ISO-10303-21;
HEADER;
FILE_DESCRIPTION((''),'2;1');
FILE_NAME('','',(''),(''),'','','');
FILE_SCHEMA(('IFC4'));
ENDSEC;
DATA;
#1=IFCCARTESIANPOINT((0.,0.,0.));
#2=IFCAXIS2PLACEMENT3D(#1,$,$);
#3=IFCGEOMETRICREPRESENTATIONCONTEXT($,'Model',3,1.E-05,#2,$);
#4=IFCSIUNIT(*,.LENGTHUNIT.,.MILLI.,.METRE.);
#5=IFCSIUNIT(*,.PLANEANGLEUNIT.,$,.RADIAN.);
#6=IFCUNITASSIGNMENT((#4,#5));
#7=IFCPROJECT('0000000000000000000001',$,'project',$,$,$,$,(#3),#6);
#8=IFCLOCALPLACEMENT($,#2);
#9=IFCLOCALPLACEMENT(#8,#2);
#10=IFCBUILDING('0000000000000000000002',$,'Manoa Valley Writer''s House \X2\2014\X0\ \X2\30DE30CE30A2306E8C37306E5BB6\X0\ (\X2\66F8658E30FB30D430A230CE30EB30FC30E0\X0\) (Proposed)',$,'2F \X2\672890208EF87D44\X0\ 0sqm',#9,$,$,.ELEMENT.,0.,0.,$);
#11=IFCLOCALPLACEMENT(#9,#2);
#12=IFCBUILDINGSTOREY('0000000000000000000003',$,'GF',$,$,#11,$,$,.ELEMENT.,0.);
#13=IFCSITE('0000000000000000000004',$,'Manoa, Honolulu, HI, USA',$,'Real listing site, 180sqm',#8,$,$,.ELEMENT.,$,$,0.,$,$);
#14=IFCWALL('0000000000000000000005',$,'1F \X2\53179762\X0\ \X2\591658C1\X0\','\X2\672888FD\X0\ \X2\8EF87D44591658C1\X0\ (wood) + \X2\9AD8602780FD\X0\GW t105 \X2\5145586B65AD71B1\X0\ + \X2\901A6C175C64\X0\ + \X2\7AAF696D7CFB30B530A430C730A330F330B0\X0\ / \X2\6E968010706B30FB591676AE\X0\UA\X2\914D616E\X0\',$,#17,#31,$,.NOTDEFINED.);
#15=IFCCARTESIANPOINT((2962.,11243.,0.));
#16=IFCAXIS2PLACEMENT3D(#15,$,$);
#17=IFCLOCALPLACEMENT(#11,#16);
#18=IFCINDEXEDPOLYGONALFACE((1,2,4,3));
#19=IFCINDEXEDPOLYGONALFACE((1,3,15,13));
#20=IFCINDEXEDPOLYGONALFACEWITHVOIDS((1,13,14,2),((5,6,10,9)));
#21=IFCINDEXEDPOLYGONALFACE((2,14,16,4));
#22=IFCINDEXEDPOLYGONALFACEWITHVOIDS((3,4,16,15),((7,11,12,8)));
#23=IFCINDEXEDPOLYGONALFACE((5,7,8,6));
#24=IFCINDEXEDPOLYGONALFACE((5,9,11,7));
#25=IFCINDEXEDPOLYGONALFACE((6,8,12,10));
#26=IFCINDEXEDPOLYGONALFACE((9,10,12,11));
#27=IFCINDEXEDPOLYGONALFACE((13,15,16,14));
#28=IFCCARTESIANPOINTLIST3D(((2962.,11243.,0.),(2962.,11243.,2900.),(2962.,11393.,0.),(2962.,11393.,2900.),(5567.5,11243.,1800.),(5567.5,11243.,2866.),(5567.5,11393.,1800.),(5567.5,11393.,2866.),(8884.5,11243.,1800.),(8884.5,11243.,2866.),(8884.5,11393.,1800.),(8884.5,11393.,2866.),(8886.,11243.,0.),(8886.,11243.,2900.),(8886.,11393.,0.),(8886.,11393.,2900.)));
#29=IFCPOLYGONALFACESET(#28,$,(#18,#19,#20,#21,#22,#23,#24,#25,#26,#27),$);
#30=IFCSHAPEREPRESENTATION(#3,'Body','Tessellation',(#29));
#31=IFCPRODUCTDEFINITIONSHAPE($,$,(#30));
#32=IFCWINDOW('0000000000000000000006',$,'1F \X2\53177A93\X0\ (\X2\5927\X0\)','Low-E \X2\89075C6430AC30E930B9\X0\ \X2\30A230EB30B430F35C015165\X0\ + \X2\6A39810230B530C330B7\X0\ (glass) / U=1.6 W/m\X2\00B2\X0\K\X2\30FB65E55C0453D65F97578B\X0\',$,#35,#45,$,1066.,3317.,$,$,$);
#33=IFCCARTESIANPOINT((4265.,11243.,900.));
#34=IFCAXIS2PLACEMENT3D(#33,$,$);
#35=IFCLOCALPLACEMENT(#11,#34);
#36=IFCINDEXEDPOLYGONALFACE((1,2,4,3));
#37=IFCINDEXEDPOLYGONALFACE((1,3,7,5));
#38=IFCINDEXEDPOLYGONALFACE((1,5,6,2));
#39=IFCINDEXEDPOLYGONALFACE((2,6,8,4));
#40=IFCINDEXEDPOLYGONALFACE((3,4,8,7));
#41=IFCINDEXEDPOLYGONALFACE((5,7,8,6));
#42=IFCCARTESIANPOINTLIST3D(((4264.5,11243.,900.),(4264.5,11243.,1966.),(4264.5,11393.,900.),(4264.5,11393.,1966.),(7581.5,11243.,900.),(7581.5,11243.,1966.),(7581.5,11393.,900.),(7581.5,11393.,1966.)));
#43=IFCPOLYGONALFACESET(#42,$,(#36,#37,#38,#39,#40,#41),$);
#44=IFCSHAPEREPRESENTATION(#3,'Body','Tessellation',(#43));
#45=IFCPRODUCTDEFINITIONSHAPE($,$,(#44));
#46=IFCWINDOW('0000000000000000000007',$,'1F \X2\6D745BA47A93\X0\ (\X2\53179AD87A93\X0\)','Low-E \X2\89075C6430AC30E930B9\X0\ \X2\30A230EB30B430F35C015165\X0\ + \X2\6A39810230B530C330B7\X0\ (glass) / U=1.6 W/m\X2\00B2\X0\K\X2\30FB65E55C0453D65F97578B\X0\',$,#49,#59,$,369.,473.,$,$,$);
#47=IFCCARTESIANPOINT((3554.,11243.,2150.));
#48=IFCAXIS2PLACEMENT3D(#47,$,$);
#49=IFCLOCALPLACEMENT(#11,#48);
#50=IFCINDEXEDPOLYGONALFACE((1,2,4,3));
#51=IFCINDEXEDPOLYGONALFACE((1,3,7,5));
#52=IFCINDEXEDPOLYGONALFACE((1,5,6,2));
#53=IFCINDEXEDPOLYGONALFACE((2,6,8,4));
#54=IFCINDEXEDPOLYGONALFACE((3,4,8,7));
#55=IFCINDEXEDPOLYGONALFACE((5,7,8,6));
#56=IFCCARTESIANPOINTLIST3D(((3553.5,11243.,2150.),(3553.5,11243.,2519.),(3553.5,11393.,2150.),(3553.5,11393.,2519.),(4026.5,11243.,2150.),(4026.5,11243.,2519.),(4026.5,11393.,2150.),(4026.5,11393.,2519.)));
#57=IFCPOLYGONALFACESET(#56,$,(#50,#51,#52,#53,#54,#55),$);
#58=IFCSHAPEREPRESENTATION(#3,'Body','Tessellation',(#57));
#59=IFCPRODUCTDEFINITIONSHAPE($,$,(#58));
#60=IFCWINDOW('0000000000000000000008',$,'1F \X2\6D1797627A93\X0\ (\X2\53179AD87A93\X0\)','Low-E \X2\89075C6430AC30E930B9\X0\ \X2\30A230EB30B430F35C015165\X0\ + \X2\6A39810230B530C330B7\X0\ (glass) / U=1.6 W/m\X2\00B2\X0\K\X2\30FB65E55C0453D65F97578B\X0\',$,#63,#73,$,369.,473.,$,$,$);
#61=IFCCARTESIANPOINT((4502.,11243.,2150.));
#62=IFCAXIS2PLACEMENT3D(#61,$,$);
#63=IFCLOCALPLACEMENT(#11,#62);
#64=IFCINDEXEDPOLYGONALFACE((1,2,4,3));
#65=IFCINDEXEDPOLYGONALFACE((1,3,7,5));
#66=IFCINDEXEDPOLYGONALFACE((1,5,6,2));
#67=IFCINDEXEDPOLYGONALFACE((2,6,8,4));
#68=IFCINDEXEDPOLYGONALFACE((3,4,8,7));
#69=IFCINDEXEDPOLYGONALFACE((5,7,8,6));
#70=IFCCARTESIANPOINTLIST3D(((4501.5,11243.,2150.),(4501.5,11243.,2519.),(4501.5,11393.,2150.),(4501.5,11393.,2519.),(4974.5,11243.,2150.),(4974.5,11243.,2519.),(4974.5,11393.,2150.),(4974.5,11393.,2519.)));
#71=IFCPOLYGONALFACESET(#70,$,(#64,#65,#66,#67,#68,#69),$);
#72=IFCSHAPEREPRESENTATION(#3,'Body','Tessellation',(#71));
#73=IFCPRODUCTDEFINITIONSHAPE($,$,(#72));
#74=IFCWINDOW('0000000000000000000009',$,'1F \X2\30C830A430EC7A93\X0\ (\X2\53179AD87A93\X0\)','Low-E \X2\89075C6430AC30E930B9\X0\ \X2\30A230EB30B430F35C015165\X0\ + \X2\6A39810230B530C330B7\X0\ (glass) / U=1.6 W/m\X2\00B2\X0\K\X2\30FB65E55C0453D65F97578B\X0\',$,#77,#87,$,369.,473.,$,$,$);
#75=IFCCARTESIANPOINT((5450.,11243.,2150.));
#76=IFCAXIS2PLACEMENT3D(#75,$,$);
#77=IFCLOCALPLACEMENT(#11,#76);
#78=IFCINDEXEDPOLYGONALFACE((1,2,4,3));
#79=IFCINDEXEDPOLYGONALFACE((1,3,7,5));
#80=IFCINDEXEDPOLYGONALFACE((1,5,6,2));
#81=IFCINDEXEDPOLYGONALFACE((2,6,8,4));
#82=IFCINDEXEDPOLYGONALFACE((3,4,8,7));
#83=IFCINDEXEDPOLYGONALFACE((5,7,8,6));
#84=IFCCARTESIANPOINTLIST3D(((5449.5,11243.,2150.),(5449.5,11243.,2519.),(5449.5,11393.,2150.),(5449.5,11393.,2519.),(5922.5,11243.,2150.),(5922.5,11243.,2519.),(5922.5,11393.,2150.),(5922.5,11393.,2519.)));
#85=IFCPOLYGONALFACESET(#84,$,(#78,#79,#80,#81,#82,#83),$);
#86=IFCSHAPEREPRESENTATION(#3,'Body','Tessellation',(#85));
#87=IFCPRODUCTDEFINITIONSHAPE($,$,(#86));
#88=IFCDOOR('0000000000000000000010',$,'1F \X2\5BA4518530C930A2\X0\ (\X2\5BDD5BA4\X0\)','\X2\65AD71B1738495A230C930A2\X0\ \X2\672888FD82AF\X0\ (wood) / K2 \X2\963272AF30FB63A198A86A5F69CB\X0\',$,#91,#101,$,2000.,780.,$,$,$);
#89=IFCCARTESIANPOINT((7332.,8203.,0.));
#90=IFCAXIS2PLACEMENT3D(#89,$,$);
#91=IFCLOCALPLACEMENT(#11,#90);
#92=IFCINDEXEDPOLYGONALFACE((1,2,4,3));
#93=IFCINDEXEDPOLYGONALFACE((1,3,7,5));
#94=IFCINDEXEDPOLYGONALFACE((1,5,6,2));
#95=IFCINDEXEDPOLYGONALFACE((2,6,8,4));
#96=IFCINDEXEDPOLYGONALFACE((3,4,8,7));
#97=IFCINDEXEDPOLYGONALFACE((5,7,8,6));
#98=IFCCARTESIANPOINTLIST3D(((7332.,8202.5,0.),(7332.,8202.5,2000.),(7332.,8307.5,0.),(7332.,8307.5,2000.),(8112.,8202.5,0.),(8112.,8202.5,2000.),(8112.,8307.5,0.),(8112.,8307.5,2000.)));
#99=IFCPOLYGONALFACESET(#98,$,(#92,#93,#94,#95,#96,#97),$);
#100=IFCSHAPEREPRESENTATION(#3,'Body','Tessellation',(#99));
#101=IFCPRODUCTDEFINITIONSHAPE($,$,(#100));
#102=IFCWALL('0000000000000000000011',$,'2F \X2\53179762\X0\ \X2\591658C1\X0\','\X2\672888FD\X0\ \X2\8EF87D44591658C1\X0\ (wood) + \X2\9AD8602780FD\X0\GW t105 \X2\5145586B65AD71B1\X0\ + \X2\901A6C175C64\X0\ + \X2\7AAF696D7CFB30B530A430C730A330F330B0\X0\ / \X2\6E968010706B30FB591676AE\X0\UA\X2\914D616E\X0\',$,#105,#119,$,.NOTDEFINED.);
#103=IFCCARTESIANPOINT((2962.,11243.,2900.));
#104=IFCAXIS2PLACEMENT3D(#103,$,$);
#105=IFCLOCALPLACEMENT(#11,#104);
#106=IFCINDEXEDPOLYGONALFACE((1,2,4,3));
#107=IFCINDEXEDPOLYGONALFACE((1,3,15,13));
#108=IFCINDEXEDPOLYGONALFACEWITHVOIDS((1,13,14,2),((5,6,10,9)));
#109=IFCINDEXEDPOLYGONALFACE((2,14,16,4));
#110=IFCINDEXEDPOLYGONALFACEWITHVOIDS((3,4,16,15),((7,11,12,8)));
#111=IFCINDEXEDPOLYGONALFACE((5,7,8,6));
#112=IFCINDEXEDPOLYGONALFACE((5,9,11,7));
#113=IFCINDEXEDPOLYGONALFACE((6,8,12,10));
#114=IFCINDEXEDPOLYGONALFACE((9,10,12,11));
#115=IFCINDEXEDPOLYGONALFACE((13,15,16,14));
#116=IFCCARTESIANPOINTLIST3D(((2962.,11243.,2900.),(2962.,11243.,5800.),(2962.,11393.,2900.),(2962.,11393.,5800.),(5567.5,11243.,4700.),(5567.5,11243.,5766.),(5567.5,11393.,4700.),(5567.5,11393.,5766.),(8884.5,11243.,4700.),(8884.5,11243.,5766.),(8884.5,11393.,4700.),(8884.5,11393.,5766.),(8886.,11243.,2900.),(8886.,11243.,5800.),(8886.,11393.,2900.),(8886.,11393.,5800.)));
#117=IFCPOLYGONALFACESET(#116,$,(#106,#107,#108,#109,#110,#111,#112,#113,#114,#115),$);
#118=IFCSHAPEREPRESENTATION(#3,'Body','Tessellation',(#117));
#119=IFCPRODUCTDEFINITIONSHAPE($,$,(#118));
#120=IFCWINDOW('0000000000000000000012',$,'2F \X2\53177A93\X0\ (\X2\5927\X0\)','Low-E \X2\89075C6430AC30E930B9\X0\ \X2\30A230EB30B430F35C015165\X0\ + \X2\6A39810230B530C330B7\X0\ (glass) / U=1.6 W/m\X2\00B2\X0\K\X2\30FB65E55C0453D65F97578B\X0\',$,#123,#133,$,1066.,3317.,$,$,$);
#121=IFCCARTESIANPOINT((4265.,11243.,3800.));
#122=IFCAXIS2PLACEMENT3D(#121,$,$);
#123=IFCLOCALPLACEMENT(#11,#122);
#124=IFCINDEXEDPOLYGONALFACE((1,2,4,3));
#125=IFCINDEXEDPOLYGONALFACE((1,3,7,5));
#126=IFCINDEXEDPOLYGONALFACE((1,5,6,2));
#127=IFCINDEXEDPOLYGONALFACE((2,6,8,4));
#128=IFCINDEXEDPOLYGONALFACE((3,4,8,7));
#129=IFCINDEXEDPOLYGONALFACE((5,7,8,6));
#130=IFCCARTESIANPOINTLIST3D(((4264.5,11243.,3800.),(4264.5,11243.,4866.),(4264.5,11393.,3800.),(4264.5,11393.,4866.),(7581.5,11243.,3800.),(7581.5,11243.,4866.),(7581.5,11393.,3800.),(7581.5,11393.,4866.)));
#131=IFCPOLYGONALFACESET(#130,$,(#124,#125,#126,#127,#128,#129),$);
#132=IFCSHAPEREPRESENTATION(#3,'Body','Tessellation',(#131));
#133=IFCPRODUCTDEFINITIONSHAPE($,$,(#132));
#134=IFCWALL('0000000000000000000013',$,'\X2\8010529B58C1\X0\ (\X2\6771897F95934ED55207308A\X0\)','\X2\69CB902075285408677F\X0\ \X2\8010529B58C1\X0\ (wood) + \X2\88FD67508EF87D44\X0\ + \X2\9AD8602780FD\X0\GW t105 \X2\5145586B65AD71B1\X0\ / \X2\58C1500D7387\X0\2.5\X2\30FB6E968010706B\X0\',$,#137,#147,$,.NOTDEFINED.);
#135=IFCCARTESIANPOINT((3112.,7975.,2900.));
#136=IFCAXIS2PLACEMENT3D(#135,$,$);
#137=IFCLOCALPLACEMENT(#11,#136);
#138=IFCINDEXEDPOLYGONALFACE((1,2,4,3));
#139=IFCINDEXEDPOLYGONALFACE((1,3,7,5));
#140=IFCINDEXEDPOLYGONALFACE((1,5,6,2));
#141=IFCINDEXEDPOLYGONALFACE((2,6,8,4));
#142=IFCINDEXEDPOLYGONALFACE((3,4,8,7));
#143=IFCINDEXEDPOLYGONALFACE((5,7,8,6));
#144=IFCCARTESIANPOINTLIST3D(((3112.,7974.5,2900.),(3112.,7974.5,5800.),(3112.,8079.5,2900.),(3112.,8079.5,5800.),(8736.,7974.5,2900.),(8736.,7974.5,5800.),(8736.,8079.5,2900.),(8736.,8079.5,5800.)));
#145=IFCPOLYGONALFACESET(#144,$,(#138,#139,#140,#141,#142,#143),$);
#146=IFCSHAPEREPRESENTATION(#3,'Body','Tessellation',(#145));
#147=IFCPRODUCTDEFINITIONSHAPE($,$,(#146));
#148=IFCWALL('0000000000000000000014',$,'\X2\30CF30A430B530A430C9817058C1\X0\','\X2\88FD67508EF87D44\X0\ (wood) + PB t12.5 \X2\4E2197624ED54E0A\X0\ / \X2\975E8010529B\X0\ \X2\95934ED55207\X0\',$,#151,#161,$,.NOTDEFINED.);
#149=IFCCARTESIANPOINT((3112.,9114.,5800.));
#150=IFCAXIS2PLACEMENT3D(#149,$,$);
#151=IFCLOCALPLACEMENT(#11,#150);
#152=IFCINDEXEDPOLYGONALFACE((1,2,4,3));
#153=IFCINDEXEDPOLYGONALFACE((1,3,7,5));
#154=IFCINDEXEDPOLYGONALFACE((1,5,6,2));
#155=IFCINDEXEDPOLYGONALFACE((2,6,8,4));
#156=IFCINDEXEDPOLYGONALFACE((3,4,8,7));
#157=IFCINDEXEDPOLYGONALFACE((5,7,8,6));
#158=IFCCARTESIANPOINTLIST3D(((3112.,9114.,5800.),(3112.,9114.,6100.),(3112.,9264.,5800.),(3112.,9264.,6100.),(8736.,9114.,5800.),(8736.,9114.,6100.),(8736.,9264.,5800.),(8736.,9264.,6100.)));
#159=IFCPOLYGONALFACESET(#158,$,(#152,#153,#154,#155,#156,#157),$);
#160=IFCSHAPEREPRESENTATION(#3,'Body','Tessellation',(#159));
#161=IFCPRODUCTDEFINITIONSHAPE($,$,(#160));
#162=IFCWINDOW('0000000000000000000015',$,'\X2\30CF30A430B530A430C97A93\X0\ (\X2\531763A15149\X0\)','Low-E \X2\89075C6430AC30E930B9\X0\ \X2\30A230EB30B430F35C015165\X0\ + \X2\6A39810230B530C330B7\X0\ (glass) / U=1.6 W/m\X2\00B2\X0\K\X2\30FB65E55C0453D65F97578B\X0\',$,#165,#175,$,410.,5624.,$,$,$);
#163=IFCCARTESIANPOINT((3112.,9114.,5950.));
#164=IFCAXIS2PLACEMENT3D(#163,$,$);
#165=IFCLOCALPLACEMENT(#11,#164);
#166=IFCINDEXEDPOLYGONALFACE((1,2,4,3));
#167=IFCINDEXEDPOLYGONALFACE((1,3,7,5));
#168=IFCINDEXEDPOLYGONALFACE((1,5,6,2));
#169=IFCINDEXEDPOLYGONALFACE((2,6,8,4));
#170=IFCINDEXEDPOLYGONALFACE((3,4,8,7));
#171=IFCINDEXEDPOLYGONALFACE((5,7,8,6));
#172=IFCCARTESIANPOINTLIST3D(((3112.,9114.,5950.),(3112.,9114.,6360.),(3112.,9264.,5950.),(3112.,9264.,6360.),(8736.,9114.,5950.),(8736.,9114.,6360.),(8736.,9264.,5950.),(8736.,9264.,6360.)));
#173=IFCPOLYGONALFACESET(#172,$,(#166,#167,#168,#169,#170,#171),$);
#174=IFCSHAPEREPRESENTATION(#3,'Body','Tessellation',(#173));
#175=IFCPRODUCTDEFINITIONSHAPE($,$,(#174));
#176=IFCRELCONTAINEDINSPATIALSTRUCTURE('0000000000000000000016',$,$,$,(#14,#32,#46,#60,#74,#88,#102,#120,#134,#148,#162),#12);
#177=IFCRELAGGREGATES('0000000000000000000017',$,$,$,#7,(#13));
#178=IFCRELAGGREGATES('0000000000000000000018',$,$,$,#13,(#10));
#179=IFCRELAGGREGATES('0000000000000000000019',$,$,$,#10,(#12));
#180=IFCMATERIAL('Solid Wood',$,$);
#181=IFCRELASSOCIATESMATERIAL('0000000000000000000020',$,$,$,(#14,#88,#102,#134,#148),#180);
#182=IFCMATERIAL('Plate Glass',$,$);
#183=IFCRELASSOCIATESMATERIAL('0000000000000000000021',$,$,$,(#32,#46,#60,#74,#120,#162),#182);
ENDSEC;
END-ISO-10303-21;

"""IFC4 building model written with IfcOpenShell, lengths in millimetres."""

from ifc_helpers import new_model, si_unit, frame, frame_2d, origin, place, context, project, spatial, rectangle, extrude, material, element, fill, save


model = new_model("IFC4")

# Units and contexts
model_context = context("Model", 3, precision=1e-05, world=origin())
ifc_project = project(units=[si_unit("LENGTHUNIT", "METRE", prefix="MILLI"), si_unit("PLANEANGLEUNIT", "RADIAN")], contexts=[model_context])

# Site, building, storey
site_placement = place(None, origin())
site = spatial("IfcSite", under=ifc_project, at=site_placement, Name="Manoa, Honolulu, HI, USA", ObjectType="Real listing site, 180sqm", CompositionType="ELEMENT", RefElevation=0.0)
building_placement = place(site_placement, origin())
building = spatial("IfcBuilding", under=site, at=building_placement, Name="Manoa Valley Writer's House — マノアの谷の家 (書斎・ピアノルーム) (Proposed)", ObjectType="2F 木造軸組 0sqm", CompositionType="ELEMENT", ElevationOfRefHeight=0.0, ElevationOfTerrain=0.0)
storey_placement = place(building_placement, origin())
storey = spatial("IfcBuildingStorey", under=building, at=storey_placement, Name="GF", CompositionType="ELEMENT", Elevation=0.0)

# Wall, openings, windows
ifc_material_1 = material(Name="Solid Wood")
wall_1_placement = place(storey_placement, frame((2962.0, 11243.0, 0.0)))
wall_1 = element("IfcWall", 1, at=wall_1_placement, inside=storey, material=ifc_material_1, Name="1F 北面 外壁", Description="木製 軸組外壁 (wood) + 高性能GW t105 充填断熱 + 通気層 + 窯業系サイディング / 準耐火・外皮UA配慮", PredefinedType="NOTDEFINED", context=model_context, shape_type="SweptSolid", body=[
    extrude(rectangle(XDim=5924.0, YDim=150.0, at=frame_2d((2962.0, 75.0))), frame((2962.0, 11243.0, 0.0)), (0.0, 0.0, 1.0), 2900.0),
])
opening_1_placement = place(storey_placement, frame((4265.0, 11243.0, 900.0)))
opening_1 = element("IfcOpeningElement", 2, at=opening_1_placement, cuts=wall_1, PredefinedType="NOTDEFINED", context=model_context, shape_type="SweptSolid", body=[
    extrude(rectangle(XDim=3317.0, YDim=150.0, at=frame_2d((1658.0, 75.0))), frame((4265.0, 11243.0, 900.0)), (0.0, 0.0, 1.0), 1066.0),
])
opening_2_placement = place(storey_placement, frame((3554.0, 11243.0, 2150.0)))
opening_2 = element("IfcOpeningElement", 3, at=opening_2_placement, cuts=wall_1, PredefinedType="NOTDEFINED", context=model_context, shape_type="SweptSolid", body=[
    extrude(rectangle(XDim=473.0, YDim=150.0, at=frame_2d((236.0, 75.0))), frame((3554.0, 11243.0, 2150.0)), (0.0, 0.0, 1.0), 369.0),
])
opening_3_placement = place(storey_placement, frame((4502.0, 11243.0, 2150.0)))
opening_3 = element("IfcOpeningElement", 4, at=opening_3_placement, cuts=wall_1, PredefinedType="NOTDEFINED", context=model_context, shape_type="SweptSolid", body=[
    extrude(rectangle(XDim=473.0, YDim=150.0, at=frame_2d((236.0, 75.0))), frame((4502.0, 11243.0, 2150.0)), (0.0, 0.0, 1.0), 369.0),
])
opening_4_placement = place(storey_placement, frame((5450.0, 11243.0, 2150.0)))
opening_4 = element("IfcOpeningElement", 5, at=opening_4_placement, cuts=wall_1, PredefinedType="NOTDEFINED", context=model_context, shape_type="SweptSolid", body=[
    extrude(rectangle(XDim=473.0, YDim=150.0, at=frame_2d((236.0, 75.0))), frame((5450.0, 11243.0, 2150.0)), (0.0, 0.0, 1.0), 369.0),
])
ifc_material_2 = material(Name="Plate Glass")
window_1_placement = place(storey_placement, frame((4265.0, 11243.0, 900.0)))
window_1 = element("IfcWindow", 6, at=window_1_placement, inside=storey, material=ifc_material_2, Name="1F 北窓 (大)", Description="Low-E 複層ガラス アルゴン封入 + 樹脂サッシ (glass) / U=1.6 W/m²K・日射取得型", OverallHeight=1066.0, OverallWidth=3317.0, context=model_context, shape_type="SweptSolid", body=[
    extrude(rectangle(XDim=3317.0, YDim=150.0, at=frame_2d((1658.0, 75.0))), frame((4265.0, 11243.0, 900.0)), (0.0, 0.0, 1.0), 1066.0),
])
fill(opening_1, window_1)
window_2_placement = place(storey_placement, frame((3554.0, 11243.0, 2150.0)))
window_2 = element("IfcWindow", 7, at=window_2_placement, inside=storey, material=ifc_material_2, Name="1F 浴室窓 (北高窓)", Description="Low-E 複層ガラス アルゴン封入 + 樹脂サッシ (glass) / U=1.6 W/m²K・日射取得型", OverallHeight=369.0, OverallWidth=473.0, context=model_context, shape_type="SweptSolid", body=[
    extrude(rectangle(XDim=473.0, YDim=150.0, at=frame_2d((236.0, 75.0))), frame((3554.0, 11243.0, 2150.0)), (0.0, 0.0, 1.0), 369.0),
])
fill(opening_2, window_2)
window_3_placement = place(storey_placement, frame((4502.0, 11243.0, 2150.0)))
window_3 = element("IfcWindow", 8, at=window_3_placement, inside=storey, material=ifc_material_2, Name="1F 洗面窓 (北高窓)", Description="Low-E 複層ガラス アルゴン封入 + 樹脂サッシ (glass) / U=1.6 W/m²K・日射取得型", OverallHeight=369.0, OverallWidth=473.0, context=model_context, shape_type="SweptSolid", body=[
    extrude(rectangle(XDim=473.0, YDim=150.0, at=frame_2d((236.0, 75.0))), frame((4502.0, 11243.0, 2150.0)), (0.0, 0.0, 1.0), 369.0),
])
fill(opening_3, window_3)
window_4_placement = place(storey_placement, frame((5450.0, 11243.0, 2150.0)))
window_4 = element("IfcWindow", 9, at=window_4_placement, inside=storey, material=ifc_material_2, Name="1F トイレ窓 (北高窓)", Description="Low-E 複層ガラス アルゴン封入 + 樹脂サッシ (glass) / U=1.6 W/m²K・日射取得型", OverallHeight=369.0, OverallWidth=473.0, context=model_context, shape_type="SweptSolid", body=[
    extrude(rectangle(XDim=473.0, YDim=150.0, at=frame_2d((236.0, 75.0))), frame((5450.0, 11243.0, 2150.0)), (0.0, 0.0, 1.0), 369.0),
])
fill(opening_4, window_4)

# Door
door_1_placement = place(storey_placement, frame((7332.0, 8203.0, 0.0)))
element("IfcDoor", 10, at=door_1_placement, inside=storey, material=ifc_material_1, Name="1F 室内ドア (寝室)", Description="断熱玄関ドア 木製芯 (wood) / K2 防犯・採風機構", OverallHeight=2000.0, OverallWidth=780.0, context=model_context, shape_type="SweptSolid", body=[
    extrude(rectangle(XDim=780.0, YDim=105.0, at=frame_2d((390.0, 52.0))), frame((7332.0, 8203.0, 0.0)), (0.0, 0.0, 1.0), 2000.0),
])

# Wall, opening, window
wall_2_placement = place(storey_placement, frame((2962.0, 11243.0, 2900.0)))
wall_2 = element("IfcWall", 11, at=wall_2_placement, inside=storey, material=ifc_material_1, Name="2F 北面 外壁", Description="木製 軸組外壁 (wood) + 高性能GW t105 充填断熱 + 通気層 + 窯業系サイディング / 準耐火・外皮UA配慮", PredefinedType="NOTDEFINED", context=model_context, shape_type="SweptSolid", body=[
    extrude(rectangle(XDim=5924.0, YDim=150.0, at=frame_2d((2962.0, 75.0))), frame((2962.0, 11243.0, 2900.0)), (0.0, 0.0, 1.0), 2900.0),
])
opening_5_placement = place(storey_placement, frame((4265.0, 11243.0, 3800.0)))
opening_5 = element("IfcOpeningElement", 12, at=opening_5_placement, cuts=wall_2, PredefinedType="NOTDEFINED", context=model_context, shape_type="SweptSolid", body=[
    extrude(rectangle(XDim=3317.0, YDim=150.0, at=frame_2d((1658.0, 75.0))), frame((4265.0, 11243.0, 3800.0)), (0.0, 0.0, 1.0), 1066.0),
])
window_5_placement = place(storey_placement, frame((4265.0, 11243.0, 3800.0)))
window_5 = element("IfcWindow", 13, at=window_5_placement, inside=storey, material=ifc_material_2, Name="2F 北窓 (大)", Description="Low-E 複層ガラス アルゴン封入 + 樹脂サッシ (glass) / U=1.6 W/m²K・日射取得型", OverallHeight=1066.0, OverallWidth=3317.0, context=model_context, shape_type="SweptSolid", body=[
    extrude(rectangle(XDim=3317.0, YDim=150.0, at=frame_2d((1658.0, 75.0))), frame((4265.0, 11243.0, 3800.0)), (0.0, 0.0, 1.0), 1066.0),
])
fill(opening_5, window_5)

# Wall
wall_3_placement = place(storey_placement, frame((3112.0, 7975.0, 2900.0)))
element("IfcWall", 14, at=wall_3_placement, inside=storey, material=ifc_material_1, Name="耐力壁 (東西間仕切り)", Description="構造用合板 耐力壁 (wood) + 製材軸組 + 高性能GW t105 充填断熱 / 壁倍率2.5・準耐火", PredefinedType="NOTDEFINED", context=model_context, shape_type="SweptSolid", body=[
    extrude(rectangle(XDim=5624.0, YDim=105.0, at=frame_2d((2812.0, 52.0))), frame((3112.0, 7975.0, 2900.0)), (0.0, 0.0, 1.0), 2900.0),
])

# Wall, opening, window
wall_4_placement = place(storey_placement, frame((3112.0, 9114.0, 5800.0)))
wall_4 = element("IfcWall", 15, at=wall_4_placement, inside=storey, material=ifc_material_1, Name="ハイサイド腰壁", Description="製材軸組 (wood) + PB t12.5 両面仕上 / 非耐力 間仕切", PredefinedType="NOTDEFINED", context=model_context, shape_type="SweptSolid", body=[
    extrude(rectangle(XDim=5624.0, YDim=150.0, at=frame_2d((2812.0, 75.0))), frame((3112.0, 9114.0, 5800.0)), (0.0, 0.0, 1.0), 700.0),
])
opening_6_placement = place(storey_placement, frame((3112.0, 9114.0, 5950.0)))
opening_6 = element("IfcOpeningElement", 16, at=opening_6_placement, cuts=wall_4, PredefinedType="NOTDEFINED", context=model_context, shape_type="SweptSolid", body=[
    extrude(rectangle(XDim=5624.0, YDim=150.0, at=frame_2d((2812.0, 75.0))), frame((3112.0, 9114.0, 5950.0)), (0.0, 0.0, 1.0), 410.0),
])
window_6_placement = place(storey_placement, frame((3112.0, 9114.0, 5950.0)))
window_6 = element("IfcWindow", 17, at=window_6_placement, inside=storey, material=ifc_material_2, Name="ハイサイド窓 (北採光)", Description="Low-E 複層ガラス アルゴン封入 + 樹脂サッシ (glass) / U=1.6 W/m²K・日射取得型", OverallHeight=410.0, OverallWidth=5624.0, context=model_context, shape_type="SweptSolid", body=[
    extrude(rectangle(XDim=5624.0, YDim=150.0, at=frame_2d((2812.0, 75.0))), frame((3112.0, 9114.0, 5950.0)), (0.0, 0.0, 1.0), 410.0),
])
fill(opening_6, window_6)

save(model, "model.ifc")
